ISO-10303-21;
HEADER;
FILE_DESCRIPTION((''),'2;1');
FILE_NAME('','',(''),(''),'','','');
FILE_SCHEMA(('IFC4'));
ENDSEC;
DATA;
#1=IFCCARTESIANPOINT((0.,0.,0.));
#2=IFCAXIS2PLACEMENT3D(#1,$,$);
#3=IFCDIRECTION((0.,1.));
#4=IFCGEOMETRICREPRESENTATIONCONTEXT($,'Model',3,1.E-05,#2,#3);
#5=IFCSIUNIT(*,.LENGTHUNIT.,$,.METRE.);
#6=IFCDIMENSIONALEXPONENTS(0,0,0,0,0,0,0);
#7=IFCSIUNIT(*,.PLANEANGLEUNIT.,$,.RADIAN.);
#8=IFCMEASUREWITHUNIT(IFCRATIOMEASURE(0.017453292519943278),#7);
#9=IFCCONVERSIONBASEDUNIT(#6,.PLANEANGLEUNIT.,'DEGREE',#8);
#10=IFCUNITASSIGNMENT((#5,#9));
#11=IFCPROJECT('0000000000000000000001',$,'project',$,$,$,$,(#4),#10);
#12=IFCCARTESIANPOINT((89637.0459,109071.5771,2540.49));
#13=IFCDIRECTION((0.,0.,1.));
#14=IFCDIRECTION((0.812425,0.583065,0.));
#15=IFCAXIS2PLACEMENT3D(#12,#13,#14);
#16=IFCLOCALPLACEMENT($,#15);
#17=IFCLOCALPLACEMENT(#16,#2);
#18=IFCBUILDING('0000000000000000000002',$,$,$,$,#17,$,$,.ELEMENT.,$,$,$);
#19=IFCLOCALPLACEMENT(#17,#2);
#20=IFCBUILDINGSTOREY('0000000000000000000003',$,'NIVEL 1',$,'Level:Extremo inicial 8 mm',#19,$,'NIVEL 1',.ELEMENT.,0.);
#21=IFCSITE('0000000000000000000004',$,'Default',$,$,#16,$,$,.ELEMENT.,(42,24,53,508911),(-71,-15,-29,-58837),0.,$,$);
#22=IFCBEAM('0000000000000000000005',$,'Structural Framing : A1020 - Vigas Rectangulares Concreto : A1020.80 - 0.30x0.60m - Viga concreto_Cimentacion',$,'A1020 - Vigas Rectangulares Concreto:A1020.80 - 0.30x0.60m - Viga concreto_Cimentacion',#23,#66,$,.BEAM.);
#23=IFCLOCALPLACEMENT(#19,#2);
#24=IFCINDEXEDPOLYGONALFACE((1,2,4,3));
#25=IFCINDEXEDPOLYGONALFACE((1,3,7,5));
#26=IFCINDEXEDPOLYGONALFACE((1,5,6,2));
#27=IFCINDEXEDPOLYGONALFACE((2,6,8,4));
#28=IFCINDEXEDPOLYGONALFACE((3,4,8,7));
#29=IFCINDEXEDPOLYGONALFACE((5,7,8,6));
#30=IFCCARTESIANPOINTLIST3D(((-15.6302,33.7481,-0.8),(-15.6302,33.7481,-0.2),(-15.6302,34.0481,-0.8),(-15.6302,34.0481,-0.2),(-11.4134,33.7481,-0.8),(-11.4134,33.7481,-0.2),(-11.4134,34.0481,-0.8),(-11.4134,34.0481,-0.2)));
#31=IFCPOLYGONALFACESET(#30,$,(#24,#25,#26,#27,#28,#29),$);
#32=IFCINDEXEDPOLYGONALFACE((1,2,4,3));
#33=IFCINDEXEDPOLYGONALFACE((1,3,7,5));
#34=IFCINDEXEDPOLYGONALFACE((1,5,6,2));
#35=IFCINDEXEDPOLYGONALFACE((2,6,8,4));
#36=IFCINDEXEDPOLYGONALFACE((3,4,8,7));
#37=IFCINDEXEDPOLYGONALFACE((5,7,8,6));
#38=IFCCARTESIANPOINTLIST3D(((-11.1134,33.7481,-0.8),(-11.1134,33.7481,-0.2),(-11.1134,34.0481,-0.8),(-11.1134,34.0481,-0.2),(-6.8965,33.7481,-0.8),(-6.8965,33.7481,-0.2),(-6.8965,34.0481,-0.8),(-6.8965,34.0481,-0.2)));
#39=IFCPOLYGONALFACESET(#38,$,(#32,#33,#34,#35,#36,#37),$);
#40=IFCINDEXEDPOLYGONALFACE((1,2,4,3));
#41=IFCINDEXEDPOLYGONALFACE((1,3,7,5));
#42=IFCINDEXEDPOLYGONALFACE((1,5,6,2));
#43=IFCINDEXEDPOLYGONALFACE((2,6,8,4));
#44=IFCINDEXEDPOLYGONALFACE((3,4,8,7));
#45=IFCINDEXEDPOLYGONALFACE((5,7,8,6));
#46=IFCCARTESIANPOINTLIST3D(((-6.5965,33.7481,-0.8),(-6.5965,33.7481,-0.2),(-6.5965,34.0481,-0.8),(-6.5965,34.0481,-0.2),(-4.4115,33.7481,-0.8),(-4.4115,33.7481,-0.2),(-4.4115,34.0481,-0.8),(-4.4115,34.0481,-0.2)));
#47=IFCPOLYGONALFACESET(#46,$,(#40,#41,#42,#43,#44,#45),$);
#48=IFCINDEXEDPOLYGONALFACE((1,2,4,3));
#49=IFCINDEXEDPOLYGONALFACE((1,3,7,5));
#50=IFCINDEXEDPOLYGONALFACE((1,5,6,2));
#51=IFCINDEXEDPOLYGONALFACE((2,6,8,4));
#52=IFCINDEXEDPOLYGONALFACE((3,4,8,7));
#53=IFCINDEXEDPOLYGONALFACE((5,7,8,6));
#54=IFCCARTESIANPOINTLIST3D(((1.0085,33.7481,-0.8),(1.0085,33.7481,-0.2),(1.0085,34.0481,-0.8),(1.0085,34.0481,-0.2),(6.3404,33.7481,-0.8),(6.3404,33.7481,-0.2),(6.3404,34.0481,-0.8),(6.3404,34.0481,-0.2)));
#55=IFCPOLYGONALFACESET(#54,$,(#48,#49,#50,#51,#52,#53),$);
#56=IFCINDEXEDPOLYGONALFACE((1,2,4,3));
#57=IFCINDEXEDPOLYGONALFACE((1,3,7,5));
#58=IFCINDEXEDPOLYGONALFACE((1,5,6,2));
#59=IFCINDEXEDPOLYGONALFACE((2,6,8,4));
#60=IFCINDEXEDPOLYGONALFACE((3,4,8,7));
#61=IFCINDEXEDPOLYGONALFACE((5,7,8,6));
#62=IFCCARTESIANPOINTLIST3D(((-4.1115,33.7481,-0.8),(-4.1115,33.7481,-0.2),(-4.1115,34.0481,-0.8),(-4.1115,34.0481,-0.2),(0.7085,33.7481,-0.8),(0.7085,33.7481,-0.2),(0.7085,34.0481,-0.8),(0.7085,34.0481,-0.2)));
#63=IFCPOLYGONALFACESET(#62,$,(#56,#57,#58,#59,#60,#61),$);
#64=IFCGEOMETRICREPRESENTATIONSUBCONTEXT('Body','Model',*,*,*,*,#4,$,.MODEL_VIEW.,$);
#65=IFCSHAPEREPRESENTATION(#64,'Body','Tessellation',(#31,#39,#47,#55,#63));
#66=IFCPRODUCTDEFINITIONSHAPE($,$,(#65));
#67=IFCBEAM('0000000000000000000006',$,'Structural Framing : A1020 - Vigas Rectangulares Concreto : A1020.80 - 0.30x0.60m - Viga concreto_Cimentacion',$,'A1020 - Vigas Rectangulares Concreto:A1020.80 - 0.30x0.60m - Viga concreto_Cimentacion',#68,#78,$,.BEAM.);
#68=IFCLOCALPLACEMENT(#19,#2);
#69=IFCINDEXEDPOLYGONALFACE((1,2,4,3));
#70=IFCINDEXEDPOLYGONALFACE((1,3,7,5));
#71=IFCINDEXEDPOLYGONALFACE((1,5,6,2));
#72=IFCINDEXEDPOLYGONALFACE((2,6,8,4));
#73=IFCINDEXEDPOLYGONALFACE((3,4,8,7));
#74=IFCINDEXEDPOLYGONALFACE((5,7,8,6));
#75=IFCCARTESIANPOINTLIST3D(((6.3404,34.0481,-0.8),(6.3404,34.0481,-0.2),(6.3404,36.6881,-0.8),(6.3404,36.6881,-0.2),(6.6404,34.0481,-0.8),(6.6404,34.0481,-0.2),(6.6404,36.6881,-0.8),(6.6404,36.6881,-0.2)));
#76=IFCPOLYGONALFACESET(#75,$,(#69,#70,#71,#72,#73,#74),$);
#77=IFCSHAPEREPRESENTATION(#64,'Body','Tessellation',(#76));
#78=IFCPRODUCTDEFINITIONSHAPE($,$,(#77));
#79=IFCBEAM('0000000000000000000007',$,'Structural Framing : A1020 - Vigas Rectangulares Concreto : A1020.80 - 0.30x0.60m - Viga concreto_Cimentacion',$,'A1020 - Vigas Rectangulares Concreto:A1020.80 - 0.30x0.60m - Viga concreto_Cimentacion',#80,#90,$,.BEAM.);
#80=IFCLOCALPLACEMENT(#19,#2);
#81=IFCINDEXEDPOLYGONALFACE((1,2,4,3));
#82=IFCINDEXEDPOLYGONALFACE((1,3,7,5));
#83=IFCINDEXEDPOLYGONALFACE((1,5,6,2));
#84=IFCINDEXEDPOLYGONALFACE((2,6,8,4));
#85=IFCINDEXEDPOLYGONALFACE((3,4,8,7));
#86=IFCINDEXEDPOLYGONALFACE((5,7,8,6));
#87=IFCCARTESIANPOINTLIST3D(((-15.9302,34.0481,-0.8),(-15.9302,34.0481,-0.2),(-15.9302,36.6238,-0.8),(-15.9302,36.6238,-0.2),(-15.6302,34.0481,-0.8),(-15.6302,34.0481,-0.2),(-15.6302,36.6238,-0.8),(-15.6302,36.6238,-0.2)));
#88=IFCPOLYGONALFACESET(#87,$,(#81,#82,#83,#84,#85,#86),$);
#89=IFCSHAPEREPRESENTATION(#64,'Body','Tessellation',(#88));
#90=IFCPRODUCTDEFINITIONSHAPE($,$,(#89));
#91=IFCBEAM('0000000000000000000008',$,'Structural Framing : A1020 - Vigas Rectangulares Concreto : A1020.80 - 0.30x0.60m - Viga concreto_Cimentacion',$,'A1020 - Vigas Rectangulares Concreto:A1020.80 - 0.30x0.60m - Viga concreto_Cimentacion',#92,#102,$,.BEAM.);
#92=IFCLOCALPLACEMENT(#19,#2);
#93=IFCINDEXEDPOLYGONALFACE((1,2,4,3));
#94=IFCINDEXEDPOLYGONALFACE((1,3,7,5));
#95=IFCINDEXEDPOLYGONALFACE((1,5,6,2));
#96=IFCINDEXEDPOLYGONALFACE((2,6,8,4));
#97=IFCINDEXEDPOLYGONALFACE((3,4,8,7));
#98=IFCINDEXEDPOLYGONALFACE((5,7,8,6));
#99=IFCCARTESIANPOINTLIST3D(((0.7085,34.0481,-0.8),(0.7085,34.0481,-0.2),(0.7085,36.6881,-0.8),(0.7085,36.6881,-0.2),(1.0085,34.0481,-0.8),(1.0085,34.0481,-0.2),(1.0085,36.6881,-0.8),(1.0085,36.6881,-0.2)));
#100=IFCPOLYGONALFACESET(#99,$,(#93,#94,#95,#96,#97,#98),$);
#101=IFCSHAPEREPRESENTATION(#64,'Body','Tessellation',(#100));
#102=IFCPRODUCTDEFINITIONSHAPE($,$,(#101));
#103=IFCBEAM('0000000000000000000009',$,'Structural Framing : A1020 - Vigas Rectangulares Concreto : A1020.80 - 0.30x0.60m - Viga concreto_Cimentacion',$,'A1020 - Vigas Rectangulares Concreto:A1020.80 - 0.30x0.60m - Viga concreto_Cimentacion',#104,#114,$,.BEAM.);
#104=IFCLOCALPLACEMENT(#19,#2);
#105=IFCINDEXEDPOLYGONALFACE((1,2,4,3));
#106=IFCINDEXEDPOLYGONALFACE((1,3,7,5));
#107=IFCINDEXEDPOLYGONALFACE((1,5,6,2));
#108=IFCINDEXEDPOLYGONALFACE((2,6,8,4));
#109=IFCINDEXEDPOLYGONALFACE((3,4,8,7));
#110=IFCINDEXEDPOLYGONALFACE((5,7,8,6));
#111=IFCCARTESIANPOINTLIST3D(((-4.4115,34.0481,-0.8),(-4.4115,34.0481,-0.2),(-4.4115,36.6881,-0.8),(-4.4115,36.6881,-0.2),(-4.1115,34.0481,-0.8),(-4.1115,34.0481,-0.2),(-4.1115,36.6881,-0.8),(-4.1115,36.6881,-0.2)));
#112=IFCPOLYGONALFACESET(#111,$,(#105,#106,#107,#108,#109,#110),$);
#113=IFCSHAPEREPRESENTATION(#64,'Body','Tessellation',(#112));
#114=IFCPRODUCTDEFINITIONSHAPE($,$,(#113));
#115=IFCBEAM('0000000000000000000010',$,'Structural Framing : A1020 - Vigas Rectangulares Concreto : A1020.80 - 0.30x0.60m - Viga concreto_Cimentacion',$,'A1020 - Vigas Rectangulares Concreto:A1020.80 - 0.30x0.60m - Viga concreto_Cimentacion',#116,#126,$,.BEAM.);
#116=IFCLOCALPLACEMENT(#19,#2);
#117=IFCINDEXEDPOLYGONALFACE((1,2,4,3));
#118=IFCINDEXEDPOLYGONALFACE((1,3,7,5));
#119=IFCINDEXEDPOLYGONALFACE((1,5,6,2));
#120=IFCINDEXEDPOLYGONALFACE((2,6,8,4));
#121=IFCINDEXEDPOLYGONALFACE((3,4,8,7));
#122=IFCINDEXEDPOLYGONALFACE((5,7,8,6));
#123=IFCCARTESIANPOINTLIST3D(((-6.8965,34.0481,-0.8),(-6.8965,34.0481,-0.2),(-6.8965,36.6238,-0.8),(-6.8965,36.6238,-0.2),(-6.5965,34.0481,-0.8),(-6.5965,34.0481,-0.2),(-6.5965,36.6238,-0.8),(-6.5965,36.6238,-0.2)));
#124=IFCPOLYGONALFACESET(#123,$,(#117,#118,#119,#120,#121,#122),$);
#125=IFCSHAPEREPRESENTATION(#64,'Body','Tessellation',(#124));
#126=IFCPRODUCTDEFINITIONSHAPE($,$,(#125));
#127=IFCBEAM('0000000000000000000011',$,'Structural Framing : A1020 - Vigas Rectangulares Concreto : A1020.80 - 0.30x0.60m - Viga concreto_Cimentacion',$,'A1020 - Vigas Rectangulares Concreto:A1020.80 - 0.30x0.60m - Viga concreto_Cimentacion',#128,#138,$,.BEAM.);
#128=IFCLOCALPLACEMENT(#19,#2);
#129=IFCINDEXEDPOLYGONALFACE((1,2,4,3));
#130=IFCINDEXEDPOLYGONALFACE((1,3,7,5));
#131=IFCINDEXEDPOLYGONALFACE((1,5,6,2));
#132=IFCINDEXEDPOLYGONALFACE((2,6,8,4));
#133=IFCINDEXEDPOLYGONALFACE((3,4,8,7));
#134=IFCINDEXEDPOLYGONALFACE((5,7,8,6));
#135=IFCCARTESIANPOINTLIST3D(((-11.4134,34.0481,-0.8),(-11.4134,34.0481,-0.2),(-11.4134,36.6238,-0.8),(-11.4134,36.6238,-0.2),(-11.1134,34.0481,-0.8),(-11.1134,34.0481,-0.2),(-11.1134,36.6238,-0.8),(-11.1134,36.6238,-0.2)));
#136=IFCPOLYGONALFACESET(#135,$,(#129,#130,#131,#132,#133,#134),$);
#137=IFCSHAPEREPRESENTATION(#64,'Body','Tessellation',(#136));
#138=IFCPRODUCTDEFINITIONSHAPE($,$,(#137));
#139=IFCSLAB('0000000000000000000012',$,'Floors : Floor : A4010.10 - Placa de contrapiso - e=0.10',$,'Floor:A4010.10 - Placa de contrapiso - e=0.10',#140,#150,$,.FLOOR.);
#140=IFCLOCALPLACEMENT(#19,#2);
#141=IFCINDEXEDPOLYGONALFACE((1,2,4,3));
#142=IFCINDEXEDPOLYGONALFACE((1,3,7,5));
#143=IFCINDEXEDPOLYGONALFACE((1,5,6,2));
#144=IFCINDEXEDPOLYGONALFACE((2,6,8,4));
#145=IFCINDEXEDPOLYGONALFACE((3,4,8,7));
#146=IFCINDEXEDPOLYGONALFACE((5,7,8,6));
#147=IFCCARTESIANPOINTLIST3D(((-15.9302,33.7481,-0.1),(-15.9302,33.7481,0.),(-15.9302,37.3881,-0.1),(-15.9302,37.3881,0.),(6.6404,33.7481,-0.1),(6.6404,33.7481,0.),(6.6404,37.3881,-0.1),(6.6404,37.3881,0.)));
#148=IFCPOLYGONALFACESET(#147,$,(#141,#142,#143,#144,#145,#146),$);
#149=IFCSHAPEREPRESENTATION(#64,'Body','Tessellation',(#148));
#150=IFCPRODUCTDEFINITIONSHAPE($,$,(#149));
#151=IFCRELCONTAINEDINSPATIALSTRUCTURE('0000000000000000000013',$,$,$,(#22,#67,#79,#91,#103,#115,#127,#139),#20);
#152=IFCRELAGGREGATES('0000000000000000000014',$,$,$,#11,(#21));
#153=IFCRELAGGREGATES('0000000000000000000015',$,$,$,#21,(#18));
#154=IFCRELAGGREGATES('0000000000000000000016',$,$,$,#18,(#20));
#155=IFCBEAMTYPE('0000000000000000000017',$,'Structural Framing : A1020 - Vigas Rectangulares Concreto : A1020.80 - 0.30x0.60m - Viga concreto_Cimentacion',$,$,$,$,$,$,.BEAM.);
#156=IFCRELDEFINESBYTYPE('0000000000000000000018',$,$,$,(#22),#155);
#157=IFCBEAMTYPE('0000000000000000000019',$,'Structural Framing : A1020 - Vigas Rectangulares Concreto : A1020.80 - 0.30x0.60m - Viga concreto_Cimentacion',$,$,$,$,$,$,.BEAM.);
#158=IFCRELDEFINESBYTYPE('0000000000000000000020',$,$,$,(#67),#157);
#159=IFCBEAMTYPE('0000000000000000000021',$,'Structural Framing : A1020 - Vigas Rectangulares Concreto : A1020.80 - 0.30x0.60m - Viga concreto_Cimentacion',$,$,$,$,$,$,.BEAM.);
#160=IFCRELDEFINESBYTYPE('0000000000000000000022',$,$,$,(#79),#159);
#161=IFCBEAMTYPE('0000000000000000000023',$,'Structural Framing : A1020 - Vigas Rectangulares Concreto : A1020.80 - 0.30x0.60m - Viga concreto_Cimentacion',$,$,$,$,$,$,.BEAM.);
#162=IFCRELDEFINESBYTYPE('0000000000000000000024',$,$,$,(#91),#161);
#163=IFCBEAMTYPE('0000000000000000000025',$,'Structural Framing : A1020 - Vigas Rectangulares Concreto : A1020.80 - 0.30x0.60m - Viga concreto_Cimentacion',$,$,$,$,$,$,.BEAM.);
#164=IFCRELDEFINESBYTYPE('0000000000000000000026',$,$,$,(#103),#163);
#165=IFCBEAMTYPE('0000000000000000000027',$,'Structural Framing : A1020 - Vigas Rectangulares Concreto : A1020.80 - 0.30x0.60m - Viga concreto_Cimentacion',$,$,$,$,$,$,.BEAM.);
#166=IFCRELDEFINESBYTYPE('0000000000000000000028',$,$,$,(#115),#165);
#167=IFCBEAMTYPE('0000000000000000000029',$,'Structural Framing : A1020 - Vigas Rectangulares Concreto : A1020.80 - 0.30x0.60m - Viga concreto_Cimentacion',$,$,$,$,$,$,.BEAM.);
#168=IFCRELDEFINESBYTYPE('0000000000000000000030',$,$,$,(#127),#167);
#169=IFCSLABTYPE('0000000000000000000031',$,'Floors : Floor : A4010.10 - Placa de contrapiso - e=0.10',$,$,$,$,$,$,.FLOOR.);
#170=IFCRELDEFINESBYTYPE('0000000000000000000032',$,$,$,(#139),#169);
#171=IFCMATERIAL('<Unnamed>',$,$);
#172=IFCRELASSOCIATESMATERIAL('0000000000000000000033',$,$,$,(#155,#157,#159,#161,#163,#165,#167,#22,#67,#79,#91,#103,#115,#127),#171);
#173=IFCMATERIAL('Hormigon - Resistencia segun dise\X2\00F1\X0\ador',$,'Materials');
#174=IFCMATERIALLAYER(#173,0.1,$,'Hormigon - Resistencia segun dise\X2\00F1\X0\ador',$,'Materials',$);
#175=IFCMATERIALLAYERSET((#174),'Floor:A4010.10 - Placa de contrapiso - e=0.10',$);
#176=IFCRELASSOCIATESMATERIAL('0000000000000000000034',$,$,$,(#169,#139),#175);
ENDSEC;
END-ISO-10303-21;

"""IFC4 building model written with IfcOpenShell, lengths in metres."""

from ifc_helpers import new_model, entity, si_unit, converted_unit, direction, frame, frame_2d, origin, place, context, subcontext, project, spatial, polyline, segment, composite_curve, rectangle, outline, extrude, source, transform, mapped, material, layer, layer_set, layer_usage, material_profile, profile_set, profile_usage, type_object, type_shapes, element, save


model = new_model("IFC4")

# Units and contexts
model_context = context("Model", 3, precision=1e-05, world=origin(), true_north=direction((0.0, 1.0)))
body_context = subcontext(model_context, "Body", "Model", "MODEL_VIEW")
ifc_project = project(units=[si_unit("LENGTHUNIT", "METRE"), converted_unit("PLANEANGLEUNIT", "DEGREE", entity("IfcRatioMeasure", 0.017453292519943278), si_unit("PLANEANGLEUNIT", "RADIAN"), dimensions=[0, 0, 0, 0, 0, 0, 0])], contexts=[model_context])

# Site, building, storey
site_placement = place(None, frame((89637.0459, 109071.5771, 2540.49), z_axis=(0.0, 0.0, 1.0), x_axis=(0.812425, 0.583065, 0.0)))
site = spatial("IfcSite", under=ifc_project, at=site_placement, Name="Default", CompositionType="ELEMENT", RefLatitude=(42, 24, 53, 508911), RefLongitude=(-71, -15, -29, -58837), RefElevation=0.0)
building_placement = place(site_placement, origin())
building = spatial("IfcBuilding", under=site, at=building_placement, CompositionType="ELEMENT")
storey_placement = place(building_placement, origin())
storey = spatial("IfcBuildingStorey", under=building, at=storey_placement, Name="NIVEL 1", ObjectType="Level:Extremo inicial 8 mm", LongName="NIVEL 1", CompositionType="ELEMENT", Elevation=0.0)

# Shared definitions
ifc_material_1 = material(Name="<Unnamed>")

# Beams
ifc_material_profile_1 = material_profile(ifc_material_1, outline(composite_curve([segment(polyline([(-0.15, -0.3, 0.0), (-0.15, 0.3, 0.0)]), True, "CONTINUOUS"), segment(polyline([(-0.15, 0.3, 0.0), (0.15, 0.3, 0.0)]), True, "CONTINUOUS"), segment(polyline([(0.15, 0.3, 0.0), (0.15, -0.3, 0.0)]), True, "CONTINUOUS"), segment(polyline([(0.15, -0.3, 0.0), (-0.15, -0.3, 0.0)]), True, "CONTINUOUS")], self_intersect=False), kind="CURVE"), Name="A1020.80 - 0.30x0.60m - Viga concreto_Cimentacion")
ifc_material_profile_2 = material_profile(ifc_material_1, outline(composite_curve([segment(polyline([(10.9726, -0.15, 0.3), (10.9726, -0.15, -0.3)]), True, "CONTINUOUS"), segment(polyline([(10.9726, -0.15, -0.3), (10.9726, 0.15, -0.3)]), True, "CONTINUOUS"), segment(polyline([(10.9726, 0.15, -0.3), (10.9726, 0.15, 0.3)]), True, "CONTINUOUS"), segment(polyline([(10.9726, 0.15, 0.3), (10.9726, -0.15, 0.3)]), True, "CONTINUOUS")], self_intersect=False), kind="CURVE"), Name="A1020.80 - 0.30x0.60m - Viga concreto_Cimentacion")
ifc_profile_set_1 = profile_set([ifc_material_profile_1, ifc_material_profile_2], Name="A1020.80 - 0.30x0.60m - Viga concreto_Cimentacion")
ifc_profile_usage_1 = profile_usage(ifc_profile_set_1, cardinal=8)
beam_type_1 = type_object("IfcBeamType", Name="Structural Framing : A1020 - Vigas Rectangulares Concreto : A1020.80 - 0.30x0.60m - Viga concreto_Cimentacion", PredefinedType="BEAM", material=ifc_profile_set_1)
shared_shape_1 = source(origin(), body_context, "Body", "SweptSolid", [
    extrude(rectangle(XDim=0.6, YDim=0.3, at=frame_2d((0.0, 0.0), x_axis=(1.0, 0.0))), frame((-15.6302, 33.8981, -0.5), z_axis=(1.0, 0.0, 0.0), x_axis=(0.0, 0.0, -1.0)), (0.0, 0.0, 1.0), 4.2168),
    extrude(rectangle(XDim=0.6, YDim=0.3, at=frame_2d((0.0, 0.0), x_axis=(1.0, 0.0))), frame((-11.1134, 33.8981, -0.5), z_axis=(1.0, 0.0, 0.0), x_axis=(0.0, 0.0, -1.0)), (0.0, 0.0, 1.0), 4.2168),
    extrude(rectangle(XDim=0.6, YDim=0.3, at=frame_2d((0.0, 0.0), x_axis=(1.0, 0.0))), frame((-6.5965, 33.8981, -0.5), z_axis=(1.0, 0.0, 0.0), x_axis=(0.0, 0.0, -1.0)), (0.0, 0.0, 1.0), 2.185),
    extrude(rectangle(XDim=0.6, YDim=0.3, at=frame_2d((0.0, 0.0), x_axis=(1.0, 0.0))), frame((1.0085, 33.8981, -0.5), z_axis=(1.0, 0.0, 0.0), x_axis=(0.0, 0.0, -1.0)), (0.0, 0.0, 1.0), 5.3319),
    extrude(rectangle(XDim=0.6, YDim=0.3, at=frame_2d((0.0, 0.0), x_axis=(1.0, 0.0))), frame((-4.1115, 33.8981, -0.5), z_axis=(1.0, 0.0, 0.0), x_axis=(0.0, 0.0, -1.0)), (0.0, 0.0, 1.0), 4.82),
])
type_shapes(beam_type_1, [shared_shape_1])
beam_1_placement = place(storey_placement, origin())
element("IfcBeam", 1, at=beam_1_placement, inside=storey, type_object=beam_type_1, material=ifc_profile_usage_1, Name="Structural Framing : A1020 - Vigas Rectangulares Concreto : A1020.80 - 0.30x0.60m - Viga concreto_Cimentacion", ObjectType="A1020 - Vigas Rectangulares Concreto:A1020.80 - 0.30x0.60m - Viga concreto_Cimentacion", PredefinedType="BEAM", context=body_context, shape_type="MappedRepresentation", body=[
    mapped(shared_shape_1, transform((0.0, 0.0, 0.0), scale=1.0)),
])
ifc_profile_usage_2 = profile_usage(ifc_profile_set_1, cardinal=8)
beam_type_2 = type_object("IfcBeamType", Name="Structural Framing : A1020 - Vigas Rectangulares Concreto : A1020.80 - 0.30x0.60m - Viga concreto_Cimentacion", PredefinedType="BEAM", material=ifc_profile_set_1)
shared_shape_2 = source(origin(), body_context, "Body", "SweptSolid", [
    extrude(rectangle(XDim=0.6, YDim=0.3, at=frame_2d((0.0, 0.0), x_axis=(0.0, 1.0))), frame((6.4904, 34.0481, -0.5), z_axis=(0.0, 1.0, 0.0), x_axis=(-1.0, 0.0, 0.0)), (0.0, 0.0, 1.0), 2.6399),
])
type_shapes(beam_type_2, [shared_shape_2])
beam_2_placement = place(storey_placement, origin())
element("IfcBeam", 2, at=beam_2_placement, inside=storey, type_object=beam_type_2, material=ifc_profile_usage_2, Name="Structural Framing : A1020 - Vigas Rectangulares Concreto : A1020.80 - 0.30x0.60m - Viga concreto_Cimentacion", ObjectType="A1020 - Vigas Rectangulares Concreto:A1020.80 - 0.30x0.60m - Viga concreto_Cimentacion", PredefinedType="BEAM", context=body_context, shape_type="MappedRepresentation", body=[
    mapped(shared_shape_2, transform((0.0, 0.0, 0.0), scale=1.0)),
])
ifc_profile_usage_3 = profile_usage(ifc_profile_set_1, cardinal=8)
beam_type_3 = type_object("IfcBeamType", Name="Structural Framing : A1020 - Vigas Rectangulares Concreto : A1020.80 - 0.30x0.60m - Viga concreto_Cimentacion", PredefinedType="BEAM", material=ifc_profile_set_1)
shared_shape_3 = source(origin(), body_context, "Body", "SweptSolid", [
    extrude(rectangle(XDim=0.6, YDim=0.3, at=frame_2d((0.0, 0.0), x_axis=(0.0, 1.0))), frame((-15.7802, 34.0481, -0.5), z_axis=(0.0, 1.0, 0.0), x_axis=(-1.0, 0.0, 0.0)), (0.0, 0.0, 1.0), 2.5757),
])
type_shapes(beam_type_3, [shared_shape_3])
beam_3_placement = place(storey_placement, origin())
element("IfcBeam", 3, at=beam_3_placement, inside=storey, type_object=beam_type_3, material=ifc_profile_usage_3, Name="Structural Framing : A1020 - Vigas Rectangulares Concreto : A1020.80 - 0.30x0.60m - Viga concreto_Cimentacion", ObjectType="A1020 - Vigas Rectangulares Concreto:A1020.80 - 0.30x0.60m - Viga concreto_Cimentacion", PredefinedType="BEAM", context=body_context, shape_type="MappedRepresentation", body=[
    mapped(shared_shape_3, transform((0.0, 0.0, 0.0), scale=1.0)),
])
ifc_profile_usage_4 = profile_usage(ifc_profile_set_1, cardinal=8)
beam_type_4 = type_object("IfcBeamType", Name="Structural Framing : A1020 - Vigas Rectangulares Concreto : A1020.80 - 0.30x0.60m - Viga concreto_Cimentacion", PredefinedType="BEAM", material=ifc_profile_set_1)
shared_shape_4 = source(origin(), body_context, "Body", "SweptSolid", [
    extrude(rectangle(XDim=0.6, YDim=0.3, at=frame_2d((0.0, 0.0), x_axis=(0.0, 1.0))), frame((0.8585, 34.0481, -0.5), z_axis=(0.0, 1.0, 0.0), x_axis=(-1.0, 0.0, 0.0)), (0.0, 0.0, 1.0), 2.6399),
])
type_shapes(beam_type_4, [shared_shape_4])
beam_4_placement = place(storey_placement, origin())
element("IfcBeam", 4, at=beam_4_placement, inside=storey, type_object=beam_type_4, material=ifc_profile_usage_4, Name="Structural Framing : A1020 - Vigas Rectangulares Concreto : A1020.80 - 0.30x0.60m - Viga concreto_Cimentacion", ObjectType="A1020 - Vigas Rectangulares Concreto:A1020.80 - 0.30x0.60m - Viga concreto_Cimentacion", PredefinedType="BEAM", context=body_context, shape_type="MappedRepresentation", body=[
    mapped(shared_shape_4, transform((0.0, 0.0, 0.0), scale=1.0)),
])
ifc_profile_usage_5 = profile_usage(ifc_profile_set_1, cardinal=8)
beam_type_5 = type_object("IfcBeamType", Name="Structural Framing : A1020 - Vigas Rectangulares Concreto : A1020.80 - 0.30x0.60m - Viga concreto_Cimentacion", PredefinedType="BEAM", material=ifc_profile_set_1)
shared_shape_5 = source(origin(), body_context, "Body", "SweptSolid", [
    extrude(rectangle(XDim=0.6, YDim=0.3, at=frame_2d((0.0, 0.0), x_axis=(0.0, 1.0))), frame((-4.2615, 34.0481, -0.5), z_axis=(0.0, 1.0, 0.0), x_axis=(-1.0, 0.0, 0.0)), (0.0, 0.0, 1.0), 2.6399),
])
type_shapes(beam_type_5, [shared_shape_5])
beam_5_placement = place(storey_placement, origin())
element("IfcBeam", 5, at=beam_5_placement, inside=storey, type_object=beam_type_5, material=ifc_profile_usage_5, Name="Structural Framing : A1020 - Vigas Rectangulares Concreto : A1020.80 - 0.30x0.60m - Viga concreto_Cimentacion", ObjectType="A1020 - Vigas Rectangulares Concreto:A1020.80 - 0.30x0.60m - Viga concreto_Cimentacion", PredefinedType="BEAM", context=body_context, shape_type="MappedRepresentation", body=[
    mapped(shared_shape_5, transform((0.0, 0.0, 0.0), scale=1.0)),
])
ifc_profile_usage_6 = profile_usage(ifc_profile_set_1, cardinal=8)
beam_type_6 = type_object("IfcBeamType", Name="Structural Framing : A1020 - Vigas Rectangulares Concreto : A1020.80 - 0.30x0.60m - Viga concreto_Cimentacion", PredefinedType="BEAM", material=ifc_profile_set_1)
shared_shape_6 = source(origin(), body_context, "Body", "SweptSolid", [
    extrude(rectangle(XDim=0.6, YDim=0.3, at=frame_2d((0.0, 0.0), x_axis=(0.0, 1.0))), frame((-6.7465, 34.0481, -0.5), z_axis=(0.0, 1.0, 0.0), x_axis=(-1.0, 0.0, 0.0)), (0.0, 0.0, 1.0), 2.5757),
])
type_shapes(beam_type_6, [shared_shape_6])
beam_6_placement = place(storey_placement, origin())
element("IfcBeam", 6, at=beam_6_placement, inside=storey, type_object=beam_type_6, material=ifc_profile_usage_6, Name="Structural Framing : A1020 - Vigas Rectangulares Concreto : A1020.80 - 0.30x0.60m - Viga concreto_Cimentacion", ObjectType="A1020 - Vigas Rectangulares Concreto:A1020.80 - 0.30x0.60m - Viga concreto_Cimentacion", PredefinedType="BEAM", context=body_context, shape_type="MappedRepresentation", body=[
    mapped(shared_shape_6, transform((0.0, 0.0, 0.0), scale=1.0)),
])
ifc_profile_usage_7 = profile_usage(ifc_profile_set_1, cardinal=8)
beam_type_7 = type_object("IfcBeamType", Name="Structural Framing : A1020 - Vigas Rectangulares Concreto : A1020.80 - 0.30x0.60m - Viga concreto_Cimentacion", PredefinedType="BEAM", material=ifc_profile_set_1)
shared_shape_7 = source(origin(), body_context, "Body", "SweptSolid", [
    extrude(rectangle(XDim=0.6, YDim=0.3, at=frame_2d((0.0, 0.0), x_axis=(0.0, 1.0))), frame((-11.2634, 34.0481, -0.5), z_axis=(0.0, 1.0, 0.0), x_axis=(-1.0, 0.0, 0.0)), (0.0, 0.0, 1.0), 2.5757),
])
type_shapes(beam_type_7, [shared_shape_7])
beam_7_placement = place(storey_placement, origin())
element("IfcBeam", 7, at=beam_7_placement, inside=storey, type_object=beam_type_7, material=ifc_profile_usage_7, Name="Structural Framing : A1020 - Vigas Rectangulares Concreto : A1020.80 - 0.30x0.60m - Viga concreto_Cimentacion", ObjectType="A1020 - Vigas Rectangulares Concreto:A1020.80 - 0.30x0.60m - Viga concreto_Cimentacion", PredefinedType="BEAM", context=body_context, shape_type="MappedRepresentation", body=[
    mapped(shared_shape_7, transform((0.0, 0.0, 0.0), scale=1.0)),
])

# Slab
ifc_material_2 = material(Name="Hormigon - Resistencia segun diseñador", Category="Materials")
ifc_layer = layer(ifc_material_2, 0.1, Name="Hormigon - Resistencia segun diseñador", Category="Materials")
ifc_layer_set = layer_set([ifc_layer], Name="Floor:A4010.10 - Placa de contrapiso - e=0.10")
ifc_layer_usage_1 = layer_usage(ifc_layer_set, "AXIS3", "POSITIVE", 0.0)
slab_type_1 = type_object("IfcSlabType", Name="Floors : Floor : A4010.10 - Placa de contrapiso - e=0.10", PredefinedType="FLOOR", material=ifc_layer_set)
slab_1_placement = place(storey_placement, origin())
element("IfcSlab", 8, at=slab_1_placement, inside=storey, type_object=slab_type_1, material=ifc_layer_usage_1, Name="Floors : Floor : A4010.10 - Placa de contrapiso - e=0.10", ObjectType="Floor:A4010.10 - Placa de contrapiso - e=0.10", PredefinedType="FLOOR", context=body_context, shape_type="SweptSolid", body=[
    extrude(rectangle(XDim=3.6399, YDim=22.5706, at=frame_2d((0.0, 0.0), x_axis=(1.0, 0.0))), frame((-4.6449, 35.5681, 0.0), z_axis=(0.0, 0.0, -1.0), x_axis=(0.0, 1.0, 0.0)), (0.0, 0.0, 1.0), 0.1),
])

save(model, "model.ifc")
